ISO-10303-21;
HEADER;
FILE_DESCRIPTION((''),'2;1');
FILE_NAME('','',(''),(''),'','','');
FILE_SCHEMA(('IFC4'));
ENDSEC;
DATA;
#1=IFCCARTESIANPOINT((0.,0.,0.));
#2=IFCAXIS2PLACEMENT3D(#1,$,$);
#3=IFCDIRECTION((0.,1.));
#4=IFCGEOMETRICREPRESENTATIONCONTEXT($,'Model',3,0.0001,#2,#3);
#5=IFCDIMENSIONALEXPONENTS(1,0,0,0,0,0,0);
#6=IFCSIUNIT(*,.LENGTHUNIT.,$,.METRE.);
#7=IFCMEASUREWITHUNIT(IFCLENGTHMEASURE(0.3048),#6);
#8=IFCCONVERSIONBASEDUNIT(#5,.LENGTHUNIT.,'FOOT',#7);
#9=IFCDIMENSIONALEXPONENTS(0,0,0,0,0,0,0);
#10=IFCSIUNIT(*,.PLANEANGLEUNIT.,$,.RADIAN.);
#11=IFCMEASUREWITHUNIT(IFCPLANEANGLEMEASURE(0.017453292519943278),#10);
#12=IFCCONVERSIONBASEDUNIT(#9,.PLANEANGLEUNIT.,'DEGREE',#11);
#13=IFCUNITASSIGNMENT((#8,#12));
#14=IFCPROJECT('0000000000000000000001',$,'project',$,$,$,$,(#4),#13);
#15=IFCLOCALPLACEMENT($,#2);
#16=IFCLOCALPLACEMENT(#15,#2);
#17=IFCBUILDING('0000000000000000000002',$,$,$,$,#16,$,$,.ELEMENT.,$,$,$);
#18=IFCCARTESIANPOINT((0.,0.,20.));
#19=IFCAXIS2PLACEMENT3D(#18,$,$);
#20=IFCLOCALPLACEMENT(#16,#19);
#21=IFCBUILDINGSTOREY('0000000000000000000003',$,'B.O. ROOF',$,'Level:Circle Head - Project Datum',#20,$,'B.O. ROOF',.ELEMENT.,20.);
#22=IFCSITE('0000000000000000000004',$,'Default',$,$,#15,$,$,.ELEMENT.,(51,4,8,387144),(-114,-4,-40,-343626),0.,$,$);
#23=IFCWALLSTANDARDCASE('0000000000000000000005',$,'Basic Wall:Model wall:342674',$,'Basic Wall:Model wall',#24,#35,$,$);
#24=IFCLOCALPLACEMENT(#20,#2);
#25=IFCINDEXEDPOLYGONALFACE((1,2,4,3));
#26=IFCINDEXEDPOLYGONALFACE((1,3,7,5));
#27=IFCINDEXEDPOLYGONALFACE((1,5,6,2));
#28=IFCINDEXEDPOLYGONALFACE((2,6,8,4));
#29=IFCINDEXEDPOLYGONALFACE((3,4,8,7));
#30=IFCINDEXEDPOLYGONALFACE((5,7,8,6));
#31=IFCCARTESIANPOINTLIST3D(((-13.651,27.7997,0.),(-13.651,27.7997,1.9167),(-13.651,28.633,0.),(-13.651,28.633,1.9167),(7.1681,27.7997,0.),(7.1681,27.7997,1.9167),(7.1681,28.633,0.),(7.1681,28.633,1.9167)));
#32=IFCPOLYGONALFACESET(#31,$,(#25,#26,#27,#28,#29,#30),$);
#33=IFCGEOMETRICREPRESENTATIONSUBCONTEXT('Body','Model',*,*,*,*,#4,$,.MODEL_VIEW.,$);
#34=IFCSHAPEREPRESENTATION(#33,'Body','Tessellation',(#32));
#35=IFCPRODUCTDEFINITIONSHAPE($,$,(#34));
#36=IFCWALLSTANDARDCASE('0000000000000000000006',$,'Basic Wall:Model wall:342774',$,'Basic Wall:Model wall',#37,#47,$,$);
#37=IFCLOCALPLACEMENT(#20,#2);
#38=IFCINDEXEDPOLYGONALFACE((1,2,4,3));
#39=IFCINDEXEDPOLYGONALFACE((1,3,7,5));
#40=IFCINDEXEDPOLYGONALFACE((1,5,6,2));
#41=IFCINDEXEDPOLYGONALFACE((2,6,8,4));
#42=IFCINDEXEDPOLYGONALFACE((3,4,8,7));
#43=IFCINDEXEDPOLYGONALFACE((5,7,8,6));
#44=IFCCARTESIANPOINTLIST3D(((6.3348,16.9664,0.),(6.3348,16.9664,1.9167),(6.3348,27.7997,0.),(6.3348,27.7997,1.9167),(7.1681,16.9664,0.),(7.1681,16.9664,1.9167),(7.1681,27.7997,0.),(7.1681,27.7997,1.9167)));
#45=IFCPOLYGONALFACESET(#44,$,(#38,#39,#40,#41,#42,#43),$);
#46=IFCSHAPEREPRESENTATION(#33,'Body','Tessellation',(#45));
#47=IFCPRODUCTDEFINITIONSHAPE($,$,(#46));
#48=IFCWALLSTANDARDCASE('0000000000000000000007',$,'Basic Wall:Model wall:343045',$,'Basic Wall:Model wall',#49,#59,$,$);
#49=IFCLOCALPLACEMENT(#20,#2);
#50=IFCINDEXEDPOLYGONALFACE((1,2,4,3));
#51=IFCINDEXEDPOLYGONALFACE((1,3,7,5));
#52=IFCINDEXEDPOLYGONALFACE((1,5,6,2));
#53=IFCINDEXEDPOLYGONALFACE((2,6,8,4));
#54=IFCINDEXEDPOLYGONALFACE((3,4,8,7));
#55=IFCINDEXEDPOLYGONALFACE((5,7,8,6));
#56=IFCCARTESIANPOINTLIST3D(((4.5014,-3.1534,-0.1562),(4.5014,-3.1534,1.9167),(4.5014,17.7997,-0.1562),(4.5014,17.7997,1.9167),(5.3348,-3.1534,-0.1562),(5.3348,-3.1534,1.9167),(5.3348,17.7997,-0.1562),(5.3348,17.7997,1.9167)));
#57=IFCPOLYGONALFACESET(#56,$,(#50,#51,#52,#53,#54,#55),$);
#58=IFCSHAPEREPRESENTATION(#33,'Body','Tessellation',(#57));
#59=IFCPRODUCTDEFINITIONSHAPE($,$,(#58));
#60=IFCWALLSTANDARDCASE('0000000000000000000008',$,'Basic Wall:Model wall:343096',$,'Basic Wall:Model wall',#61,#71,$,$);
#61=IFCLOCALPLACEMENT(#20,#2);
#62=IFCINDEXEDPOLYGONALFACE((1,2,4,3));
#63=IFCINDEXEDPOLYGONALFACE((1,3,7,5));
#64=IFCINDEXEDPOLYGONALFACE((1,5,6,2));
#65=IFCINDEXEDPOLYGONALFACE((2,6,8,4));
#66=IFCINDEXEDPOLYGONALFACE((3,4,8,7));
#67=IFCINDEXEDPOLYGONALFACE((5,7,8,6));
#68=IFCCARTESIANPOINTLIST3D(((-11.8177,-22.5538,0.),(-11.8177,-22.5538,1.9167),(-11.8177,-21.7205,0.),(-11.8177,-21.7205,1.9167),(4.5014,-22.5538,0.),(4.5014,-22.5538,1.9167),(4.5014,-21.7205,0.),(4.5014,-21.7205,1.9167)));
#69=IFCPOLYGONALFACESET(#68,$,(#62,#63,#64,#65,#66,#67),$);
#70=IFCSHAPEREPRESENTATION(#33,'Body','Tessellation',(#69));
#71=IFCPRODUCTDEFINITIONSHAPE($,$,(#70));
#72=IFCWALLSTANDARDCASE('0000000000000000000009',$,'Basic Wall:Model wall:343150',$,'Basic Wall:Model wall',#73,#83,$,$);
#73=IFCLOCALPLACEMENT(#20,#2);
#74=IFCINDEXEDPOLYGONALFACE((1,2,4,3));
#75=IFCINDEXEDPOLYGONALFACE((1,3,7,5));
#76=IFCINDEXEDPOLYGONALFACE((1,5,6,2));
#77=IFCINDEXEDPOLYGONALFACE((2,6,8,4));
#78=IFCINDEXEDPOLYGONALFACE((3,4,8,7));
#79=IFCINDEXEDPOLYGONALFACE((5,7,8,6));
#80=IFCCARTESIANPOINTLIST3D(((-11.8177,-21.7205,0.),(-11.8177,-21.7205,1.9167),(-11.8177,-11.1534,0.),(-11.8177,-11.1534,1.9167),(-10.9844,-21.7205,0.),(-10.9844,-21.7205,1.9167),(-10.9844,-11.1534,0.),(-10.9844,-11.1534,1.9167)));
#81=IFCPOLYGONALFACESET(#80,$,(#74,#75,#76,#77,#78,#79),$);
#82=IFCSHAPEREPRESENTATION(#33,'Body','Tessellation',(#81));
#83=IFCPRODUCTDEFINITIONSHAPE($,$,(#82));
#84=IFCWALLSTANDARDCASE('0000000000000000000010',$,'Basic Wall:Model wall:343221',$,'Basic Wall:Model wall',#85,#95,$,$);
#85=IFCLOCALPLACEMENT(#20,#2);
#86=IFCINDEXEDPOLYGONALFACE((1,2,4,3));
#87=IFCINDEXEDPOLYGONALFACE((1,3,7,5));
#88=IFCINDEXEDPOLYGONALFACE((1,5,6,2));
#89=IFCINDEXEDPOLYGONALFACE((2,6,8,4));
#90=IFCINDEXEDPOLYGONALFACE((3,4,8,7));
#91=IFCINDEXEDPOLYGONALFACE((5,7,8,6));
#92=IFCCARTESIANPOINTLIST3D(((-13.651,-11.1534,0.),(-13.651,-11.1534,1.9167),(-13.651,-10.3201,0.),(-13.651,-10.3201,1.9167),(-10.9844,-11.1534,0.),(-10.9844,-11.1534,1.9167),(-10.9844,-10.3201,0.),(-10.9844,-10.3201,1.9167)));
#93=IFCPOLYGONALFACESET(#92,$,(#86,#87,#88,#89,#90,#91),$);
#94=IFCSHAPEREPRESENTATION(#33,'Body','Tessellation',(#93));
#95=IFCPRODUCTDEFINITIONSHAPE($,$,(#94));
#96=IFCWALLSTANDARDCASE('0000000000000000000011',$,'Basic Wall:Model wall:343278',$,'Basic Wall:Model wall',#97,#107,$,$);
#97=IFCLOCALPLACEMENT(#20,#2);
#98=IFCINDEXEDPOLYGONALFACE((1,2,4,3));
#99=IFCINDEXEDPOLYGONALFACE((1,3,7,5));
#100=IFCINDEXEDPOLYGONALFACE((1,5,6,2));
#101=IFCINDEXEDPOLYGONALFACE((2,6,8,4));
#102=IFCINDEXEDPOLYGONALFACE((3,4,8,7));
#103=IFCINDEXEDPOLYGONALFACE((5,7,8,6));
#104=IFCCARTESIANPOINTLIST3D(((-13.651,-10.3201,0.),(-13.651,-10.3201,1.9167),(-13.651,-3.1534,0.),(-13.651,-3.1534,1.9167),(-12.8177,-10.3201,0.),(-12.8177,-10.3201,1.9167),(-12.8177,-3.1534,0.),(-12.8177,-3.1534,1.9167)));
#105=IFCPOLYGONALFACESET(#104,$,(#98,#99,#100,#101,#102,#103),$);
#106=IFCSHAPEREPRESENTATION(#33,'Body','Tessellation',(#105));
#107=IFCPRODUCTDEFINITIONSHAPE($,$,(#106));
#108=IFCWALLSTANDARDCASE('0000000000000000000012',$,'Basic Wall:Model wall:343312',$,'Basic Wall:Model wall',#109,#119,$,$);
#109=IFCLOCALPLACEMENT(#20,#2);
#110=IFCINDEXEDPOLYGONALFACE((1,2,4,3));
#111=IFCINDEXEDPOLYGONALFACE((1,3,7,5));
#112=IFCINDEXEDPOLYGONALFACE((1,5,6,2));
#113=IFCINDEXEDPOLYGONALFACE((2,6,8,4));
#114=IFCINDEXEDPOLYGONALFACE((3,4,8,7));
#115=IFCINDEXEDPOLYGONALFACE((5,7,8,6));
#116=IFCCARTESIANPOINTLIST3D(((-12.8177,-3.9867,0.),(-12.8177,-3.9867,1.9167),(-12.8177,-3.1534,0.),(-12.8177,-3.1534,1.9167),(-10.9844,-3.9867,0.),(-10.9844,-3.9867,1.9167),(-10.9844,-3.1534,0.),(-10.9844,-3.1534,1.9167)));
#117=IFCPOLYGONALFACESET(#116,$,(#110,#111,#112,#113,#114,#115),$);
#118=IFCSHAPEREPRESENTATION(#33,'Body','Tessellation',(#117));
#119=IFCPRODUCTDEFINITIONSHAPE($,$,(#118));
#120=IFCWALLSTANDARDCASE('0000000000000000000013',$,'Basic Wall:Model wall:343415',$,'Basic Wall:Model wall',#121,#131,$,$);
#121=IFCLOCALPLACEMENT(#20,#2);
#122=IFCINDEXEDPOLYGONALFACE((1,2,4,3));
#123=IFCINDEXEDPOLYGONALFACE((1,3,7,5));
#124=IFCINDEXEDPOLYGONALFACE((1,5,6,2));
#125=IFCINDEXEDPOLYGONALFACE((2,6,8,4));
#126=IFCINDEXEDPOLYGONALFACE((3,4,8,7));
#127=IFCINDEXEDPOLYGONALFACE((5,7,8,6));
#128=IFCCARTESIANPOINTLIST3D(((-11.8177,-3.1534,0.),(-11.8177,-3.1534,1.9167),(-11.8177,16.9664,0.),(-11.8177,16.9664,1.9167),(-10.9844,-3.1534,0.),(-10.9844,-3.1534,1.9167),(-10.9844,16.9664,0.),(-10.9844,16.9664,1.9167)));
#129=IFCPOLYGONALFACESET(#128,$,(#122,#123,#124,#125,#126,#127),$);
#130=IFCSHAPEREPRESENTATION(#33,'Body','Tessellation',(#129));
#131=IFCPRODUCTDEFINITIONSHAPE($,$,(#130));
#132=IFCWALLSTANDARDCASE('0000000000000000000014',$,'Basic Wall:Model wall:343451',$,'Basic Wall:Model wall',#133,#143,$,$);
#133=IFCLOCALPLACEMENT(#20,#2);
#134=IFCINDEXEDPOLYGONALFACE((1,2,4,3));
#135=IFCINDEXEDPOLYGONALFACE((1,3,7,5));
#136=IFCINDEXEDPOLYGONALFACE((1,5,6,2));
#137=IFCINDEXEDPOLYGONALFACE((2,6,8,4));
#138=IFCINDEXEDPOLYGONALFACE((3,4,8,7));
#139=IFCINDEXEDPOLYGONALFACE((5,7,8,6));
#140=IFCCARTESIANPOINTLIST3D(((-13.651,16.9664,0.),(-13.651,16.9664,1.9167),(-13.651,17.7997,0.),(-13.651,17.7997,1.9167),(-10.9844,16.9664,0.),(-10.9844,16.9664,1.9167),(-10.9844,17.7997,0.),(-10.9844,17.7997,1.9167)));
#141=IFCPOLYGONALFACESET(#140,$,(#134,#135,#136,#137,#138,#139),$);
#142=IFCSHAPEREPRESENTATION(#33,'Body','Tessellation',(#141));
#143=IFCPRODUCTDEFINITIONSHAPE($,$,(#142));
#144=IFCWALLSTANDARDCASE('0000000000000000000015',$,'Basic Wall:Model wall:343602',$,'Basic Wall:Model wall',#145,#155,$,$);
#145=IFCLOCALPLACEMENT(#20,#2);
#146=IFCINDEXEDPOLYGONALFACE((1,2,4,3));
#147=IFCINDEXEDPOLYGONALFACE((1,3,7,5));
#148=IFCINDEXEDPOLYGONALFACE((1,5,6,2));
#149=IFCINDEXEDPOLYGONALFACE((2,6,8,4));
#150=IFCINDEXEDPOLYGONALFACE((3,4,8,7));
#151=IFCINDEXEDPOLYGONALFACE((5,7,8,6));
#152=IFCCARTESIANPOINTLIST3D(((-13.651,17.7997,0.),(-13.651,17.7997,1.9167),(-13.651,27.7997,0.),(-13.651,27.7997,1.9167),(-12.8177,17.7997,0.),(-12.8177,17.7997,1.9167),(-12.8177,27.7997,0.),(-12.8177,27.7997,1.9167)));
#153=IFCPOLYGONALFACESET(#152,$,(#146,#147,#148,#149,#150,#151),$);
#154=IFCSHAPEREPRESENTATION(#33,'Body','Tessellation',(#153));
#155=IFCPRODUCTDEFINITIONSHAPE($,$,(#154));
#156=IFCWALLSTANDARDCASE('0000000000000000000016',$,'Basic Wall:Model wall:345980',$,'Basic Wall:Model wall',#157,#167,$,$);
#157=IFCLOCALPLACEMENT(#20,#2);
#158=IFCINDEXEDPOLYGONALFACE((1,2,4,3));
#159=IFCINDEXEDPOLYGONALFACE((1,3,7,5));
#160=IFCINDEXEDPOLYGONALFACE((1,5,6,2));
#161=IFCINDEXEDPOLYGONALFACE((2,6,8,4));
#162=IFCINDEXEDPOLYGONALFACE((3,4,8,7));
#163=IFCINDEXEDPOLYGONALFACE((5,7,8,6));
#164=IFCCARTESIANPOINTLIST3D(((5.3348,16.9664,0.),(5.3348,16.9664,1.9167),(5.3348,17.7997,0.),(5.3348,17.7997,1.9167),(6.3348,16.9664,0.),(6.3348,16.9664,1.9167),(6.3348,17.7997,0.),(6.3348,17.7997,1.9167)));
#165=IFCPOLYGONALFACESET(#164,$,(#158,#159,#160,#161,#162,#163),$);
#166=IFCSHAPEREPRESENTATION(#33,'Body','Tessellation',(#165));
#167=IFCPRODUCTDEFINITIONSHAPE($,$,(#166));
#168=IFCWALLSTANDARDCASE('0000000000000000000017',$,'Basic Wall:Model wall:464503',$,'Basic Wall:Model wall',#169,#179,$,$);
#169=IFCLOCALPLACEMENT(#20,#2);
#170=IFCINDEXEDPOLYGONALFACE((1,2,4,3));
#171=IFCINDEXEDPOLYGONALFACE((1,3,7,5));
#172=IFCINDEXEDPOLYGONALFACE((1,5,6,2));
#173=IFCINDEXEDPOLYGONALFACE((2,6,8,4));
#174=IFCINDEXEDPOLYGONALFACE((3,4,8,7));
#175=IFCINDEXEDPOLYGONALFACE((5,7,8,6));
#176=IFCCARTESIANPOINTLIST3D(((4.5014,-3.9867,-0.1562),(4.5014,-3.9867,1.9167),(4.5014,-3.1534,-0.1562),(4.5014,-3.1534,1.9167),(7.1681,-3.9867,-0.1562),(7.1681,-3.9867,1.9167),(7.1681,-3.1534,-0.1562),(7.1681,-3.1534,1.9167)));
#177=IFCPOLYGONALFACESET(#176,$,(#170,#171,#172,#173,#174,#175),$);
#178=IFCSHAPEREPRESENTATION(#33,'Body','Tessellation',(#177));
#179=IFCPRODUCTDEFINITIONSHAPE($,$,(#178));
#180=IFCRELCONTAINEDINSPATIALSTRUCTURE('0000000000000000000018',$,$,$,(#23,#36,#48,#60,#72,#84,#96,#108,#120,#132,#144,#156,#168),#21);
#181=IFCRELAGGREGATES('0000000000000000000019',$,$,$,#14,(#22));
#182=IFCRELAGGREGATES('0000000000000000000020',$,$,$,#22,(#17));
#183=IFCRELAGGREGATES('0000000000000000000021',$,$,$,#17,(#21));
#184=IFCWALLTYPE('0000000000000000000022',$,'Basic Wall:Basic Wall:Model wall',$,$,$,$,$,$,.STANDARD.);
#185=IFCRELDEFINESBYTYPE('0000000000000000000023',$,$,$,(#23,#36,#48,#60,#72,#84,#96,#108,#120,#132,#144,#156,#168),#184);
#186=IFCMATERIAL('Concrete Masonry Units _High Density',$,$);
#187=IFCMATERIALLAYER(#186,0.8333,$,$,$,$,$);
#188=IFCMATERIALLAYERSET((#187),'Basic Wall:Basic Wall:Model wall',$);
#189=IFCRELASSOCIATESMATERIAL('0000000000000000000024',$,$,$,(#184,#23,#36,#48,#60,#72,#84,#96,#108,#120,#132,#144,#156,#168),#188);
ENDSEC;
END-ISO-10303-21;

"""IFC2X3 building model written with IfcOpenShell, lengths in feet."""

from ifc_helpers import new_model, entity, si_unit, converted_unit, direction, frame, frame_2d, origin, place, context, subcontext, project, spatial, rectangle, extrude, material, layer, layer_set, layer_usage, type_object, element, save


model = new_model("IFC2X3")

# Units and contexts
model_context = context("Model", 3, precision=0.0001, world=origin(), true_north=direction((0.0, 1.0)))
body_context = subcontext(model_context, "Body", "Model", "MODEL_VIEW")
ifc_project = project(units=[converted_unit("LENGTHUNIT", "FOOT", entity("IfcLengthMeasure", 0.3048), si_unit("LENGTHUNIT", "METRE"), dimensions=[1, 0, 0, 0, 0, 0, 0]), converted_unit("PLANEANGLEUNIT", "DEGREE", entity("IfcPlaneAngleMeasure", 0.017453292519943278), si_unit("PLANEANGLEUNIT", "RADIAN"), dimensions=[0, 0, 0, 0, 0, 0, 0])], contexts=[model_context])

# Site, building, storey
site_placement = place(None, origin())
site = spatial("IfcSite", under=ifc_project, at=site_placement, Name="Default", CompositionType="ELEMENT", RefLatitude=(51, 4, 8, 387144), RefLongitude=(-114, -4, -40, -343626), RefElevation=0.0)
building_placement = place(site_placement, origin())
building = spatial("IfcBuilding", under=site, at=building_placement, CompositionType="ELEMENT")
storey_placement = place(building_placement, frame((0.0, 0.0, 20.0)))
storey = spatial("IfcBuildingStorey", under=building, at=storey_placement, Name="B.O. ROOF", ObjectType="Level:Circle Head - Project Datum", LongName="B.O. ROOF", CompositionType="ELEMENT", Elevation=20.0)

# Walls
ifc_material_1 = material(Name="Concrete Masonry Units _High Density")
ifc_layer = layer(ifc_material_1, 0.8333)
ifc_layer_set = layer_set([ifc_layer], Name="Basic Wall:Basic Wall:Model wall")
ifc_layer_usage_1 = layer_usage(ifc_layer_set, "AXIS2", "NEGATIVE", 0.4167)
wall_type = type_object("IfcWallType", Name="Basic Wall:Basic Wall:Model wall", PredefinedType="STANDARD", material=ifc_layer_set)
wall_1_placement = place(storey_placement, frame((-13.651, 28.2164, 0.0)))
element("IfcWallStandardCase", 1, at=wall_1_placement, inside=storey, type_object=wall_type, material=ifc_layer_usage_1, Name="Basic Wall:Model wall:342674", ObjectType="Basic Wall:Model wall", context=body_context, shape_type="SweptSolid", body=[
    extrude(rectangle(XDim=20.8192, YDim=0.8333, at=frame_2d((10.4096, 0.0), x_axis=(-1.0, 0.0))), origin(), (0.0, 0.0, 1.0), 1.9167),
])
ifc_layer_usage_2 = layer_usage(ifc_layer_set, "AXIS2", "NEGATIVE", 0.4167)
wall_2_placement = place(storey_placement, frame((6.7514, 27.7997, 0.0), z_axis=(0.0, 0.0, 1.0), x_axis=(0.0, -1.0, 0.0)))
element("IfcWallStandardCase", 2, at=wall_2_placement, inside=storey, type_object=wall_type, material=ifc_layer_usage_2, Name="Basic Wall:Model wall:342774", ObjectType="Basic Wall:Model wall", context=body_context, shape_type="SweptSolid", body=[
    extrude(rectangle(XDim=10.8333, YDim=0.8333, at=frame_2d((5.4167, 0.0), x_axis=(-1.0, 0.0))), origin(), (0.0, 0.0, 1.0), 1.9167),
])
ifc_layer_usage_3 = layer_usage(ifc_layer_set, "AXIS2", "NEGATIVE", 0.4167)
wall_3_placement = place(storey_placement, frame((4.9181, 17.7997, -0.1562), z_axis=(0.0, 0.0, 1.0), x_axis=(0.0, -1.0, 0.0)))
element("IfcWallStandardCase", 3, at=wall_3_placement, inside=storey, type_object=wall_type, material=ifc_layer_usage_3, Name="Basic Wall:Model wall:343045", ObjectType="Basic Wall:Model wall", context=body_context, shape_type="SweptSolid", body=[
    extrude(rectangle(XDim=20.9531, YDim=0.8333, at=frame_2d((10.4766, 0.0), x_axis=(-1.0, 0.0))), origin(), (0.0, 0.0, 1.0), 2.0728),
])
ifc_layer_usage_4 = layer_usage(ifc_layer_set, "AXIS2", "NEGATIVE", 0.4167)
wall_4_placement = place(storey_placement, frame((4.5014, -22.1371, 0.0), z_axis=(0.0, 0.0, 1.0), x_axis=(-1.0, 0.0, 0.0)))
element("IfcWallStandardCase", 4, at=wall_4_placement, inside=storey, type_object=wall_type, material=ifc_layer_usage_4, Name="Basic Wall:Model wall:343096", ObjectType="Basic Wall:Model wall", context=body_context, shape_type="SweptSolid", body=[
    extrude(rectangle(XDim=16.3192, YDim=0.8333, at=frame_2d((8.1596, 0.0), x_axis=(-1.0, 0.0))), origin(), (0.0, 0.0, 1.0), 1.9167),
])
ifc_layer_usage_5 = layer_usage(ifc_layer_set, "AXIS2", "NEGATIVE", 0.4167)
wall_5_placement = place(storey_placement, frame((-11.401, -21.7205, 0.0), z_axis=(0.0, 0.0, 1.0), x_axis=(0.0, 1.0, 0.0)))
element("IfcWallStandardCase", 5, at=wall_5_placement, inside=storey, type_object=wall_type, material=ifc_layer_usage_5, Name="Basic Wall:Model wall:343150", ObjectType="Basic Wall:Model wall", context=body_context, shape_type="SweptSolid", body=[
    extrude(rectangle(XDim=10.5671, YDim=0.8333, at=frame_2d((5.2835, 0.0), x_axis=(-1.0, 0.0))), origin(), (0.0, 0.0, 1.0), 1.9167),
])
ifc_layer_usage_6 = layer_usage(ifc_layer_set, "AXIS2", "NEGATIVE", 0.4167)
wall_6_placement = place(storey_placement, frame((-10.9844, -10.7367, 0.0), z_axis=(0.0, 0.0, 1.0), x_axis=(-1.0, 0.0, 0.0)))
element("IfcWallStandardCase", 6, at=wall_6_placement, inside=storey, type_object=wall_type, material=ifc_layer_usage_6, Name="Basic Wall:Model wall:343221", ObjectType="Basic Wall:Model wall", context=body_context, shape_type="SweptSolid", body=[
    extrude(rectangle(XDim=2.6667, YDim=0.8333, at=frame_2d((1.3333, 0.0), x_axis=(-1.0, 0.0))), origin(), (0.0, 0.0, 1.0), 1.9167),
])
ifc_layer_usage_7 = layer_usage(ifc_layer_set, "AXIS2", "NEGATIVE", 0.4167)
wall_7_placement = place(storey_placement, frame((-13.2344, -10.3201, 0.0), z_axis=(0.0, 0.0, 1.0), x_axis=(0.0, 1.0, 0.0)))
element("IfcWallStandardCase", 7, at=wall_7_placement, inside=storey, type_object=wall_type, material=ifc_layer_usage_7, Name="Basic Wall:Model wall:343278", ObjectType="Basic Wall:Model wall", context=body_context, shape_type="SweptSolid", body=[
    extrude(rectangle(XDim=7.1667, YDim=0.8333, at=frame_2d((3.5833, 0.0), x_axis=(-1.0, 0.0))), origin(), (0.0, 0.0, 1.0), 1.9167),
])
ifc_layer_usage_8 = layer_usage(ifc_layer_set, "AXIS2", "NEGATIVE", 0.4167)
wall_8_placement = place(storey_placement, frame((-12.8177, -3.5701, 0.0)))
element("IfcWallStandardCase", 8, at=wall_8_placement, inside=storey, type_object=wall_type, material=ifc_layer_usage_8, Name="Basic Wall:Model wall:343312", ObjectType="Basic Wall:Model wall", context=body_context, shape_type="SweptSolid", body=[
    extrude(rectangle(XDim=1.8333, YDim=0.8333, at=frame_2d((0.9167, 0.0), x_axis=(-1.0, 0.0))), origin(), (0.0, 0.0, 1.0), 1.9167),
])
ifc_layer_usage_9 = layer_usage(ifc_layer_set, "AXIS2", "NEGATIVE", 0.4167)
wall_9_placement = place(storey_placement, frame((-11.401, -3.1534, 0.0), z_axis=(0.0, 0.0, 1.0), x_axis=(0.0, 1.0, 0.0)))
element("IfcWallStandardCase", 9, at=wall_9_placement, inside=storey, type_object=wall_type, material=ifc_layer_usage_9, Name="Basic Wall:Model wall:343415", ObjectType="Basic Wall:Model wall", context=body_context, shape_type="SweptSolid", body=[
    extrude(rectangle(XDim=20.1198, YDim=0.8333, at=frame_2d((10.0599, 0.0), x_axis=(-1.0, 0.0))), origin(), (0.0, 0.0, 1.0), 1.9167),
])
ifc_layer_usage_10 = layer_usage(ifc_layer_set, "AXIS2", "NEGATIVE", 0.4167)
wall_10_placement = place(storey_placement, frame((-10.9844, 17.383, 0.0), z_axis=(0.0, 0.0, 1.0), x_axis=(-1.0, 0.0, 0.0)))
element("IfcWallStandardCase", 10, at=wall_10_placement, inside=storey, type_object=wall_type, material=ifc_layer_usage_10, Name="Basic Wall:Model wall:343451", ObjectType="Basic Wall:Model wall", context=body_context, shape_type="SweptSolid", body=[
    extrude(rectangle(XDim=2.6667, YDim=0.8333, at=frame_2d((1.3333, 0.0), x_axis=(-1.0, 0.0))), origin(), (0.0, 0.0, 1.0), 1.9167),
])
ifc_layer_usage_11 = layer_usage(ifc_layer_set, "AXIS2", "NEGATIVE", 0.4167)
wall_11_placement = place(storey_placement, frame((-13.2344, 17.7997, 0.0), z_axis=(0.0, 0.0, 1.0), x_axis=(0.0, 1.0, 0.0)))
element("IfcWallStandardCase", 11, at=wall_11_placement, inside=storey, type_object=wall_type, material=ifc_layer_usage_11, Name="Basic Wall:Model wall:343602", ObjectType="Basic Wall:Model wall", context=body_context, shape_type="SweptSolid", body=[
    extrude(rectangle(XDim=10.0, YDim=0.8333, at=frame_2d((5.0, 0.0), x_axis=(-1.0, 0.0))), origin(), (0.0, 0.0, 1.0), 1.9167),
])
ifc_layer_usage_12 = layer_usage(ifc_layer_set, "AXIS2", "NEGATIVE", 0.4167)
wall_12_placement = place(storey_placement, frame((5.3348, 17.383, 0.0)))
element("IfcWallStandardCase", 12, at=wall_12_placement, inside=storey, type_object=wall_type, material=ifc_layer_usage_12, Name="Basic Wall:Model wall:345980", ObjectType="Basic Wall:Model wall", context=body_context, shape_type="SweptSolid", body=[
    extrude(rectangle(XDim=1.0, YDim=0.8333, at=frame_2d((0.5, 0.0), x_axis=(-1.0, 0.0))), origin(), (0.0, 0.0, 1.0), 1.9167),
])
ifc_layer_usage_13 = layer_usage(ifc_layer_set, "AXIS2", "NEGATIVE", 0.4167)
wall_13_placement = place(storey_placement, frame((4.5014, -3.5701, -0.1562)))
element("IfcWallStandardCase", 13, at=wall_13_placement, inside=storey, type_object=wall_type, material=ifc_layer_usage_13, Name="Basic Wall:Model wall:464503", ObjectType="Basic Wall:Model wall", context=body_context, shape_type="SweptSolid", body=[
    extrude(rectangle(XDim=2.6667, YDim=0.8333, at=frame_2d((1.3333, 0.0), x_axis=(-1.0, 0.0))), origin(), (0.0, 0.0, 1.0), 2.0728),
])

save(model, "model.ifc")
